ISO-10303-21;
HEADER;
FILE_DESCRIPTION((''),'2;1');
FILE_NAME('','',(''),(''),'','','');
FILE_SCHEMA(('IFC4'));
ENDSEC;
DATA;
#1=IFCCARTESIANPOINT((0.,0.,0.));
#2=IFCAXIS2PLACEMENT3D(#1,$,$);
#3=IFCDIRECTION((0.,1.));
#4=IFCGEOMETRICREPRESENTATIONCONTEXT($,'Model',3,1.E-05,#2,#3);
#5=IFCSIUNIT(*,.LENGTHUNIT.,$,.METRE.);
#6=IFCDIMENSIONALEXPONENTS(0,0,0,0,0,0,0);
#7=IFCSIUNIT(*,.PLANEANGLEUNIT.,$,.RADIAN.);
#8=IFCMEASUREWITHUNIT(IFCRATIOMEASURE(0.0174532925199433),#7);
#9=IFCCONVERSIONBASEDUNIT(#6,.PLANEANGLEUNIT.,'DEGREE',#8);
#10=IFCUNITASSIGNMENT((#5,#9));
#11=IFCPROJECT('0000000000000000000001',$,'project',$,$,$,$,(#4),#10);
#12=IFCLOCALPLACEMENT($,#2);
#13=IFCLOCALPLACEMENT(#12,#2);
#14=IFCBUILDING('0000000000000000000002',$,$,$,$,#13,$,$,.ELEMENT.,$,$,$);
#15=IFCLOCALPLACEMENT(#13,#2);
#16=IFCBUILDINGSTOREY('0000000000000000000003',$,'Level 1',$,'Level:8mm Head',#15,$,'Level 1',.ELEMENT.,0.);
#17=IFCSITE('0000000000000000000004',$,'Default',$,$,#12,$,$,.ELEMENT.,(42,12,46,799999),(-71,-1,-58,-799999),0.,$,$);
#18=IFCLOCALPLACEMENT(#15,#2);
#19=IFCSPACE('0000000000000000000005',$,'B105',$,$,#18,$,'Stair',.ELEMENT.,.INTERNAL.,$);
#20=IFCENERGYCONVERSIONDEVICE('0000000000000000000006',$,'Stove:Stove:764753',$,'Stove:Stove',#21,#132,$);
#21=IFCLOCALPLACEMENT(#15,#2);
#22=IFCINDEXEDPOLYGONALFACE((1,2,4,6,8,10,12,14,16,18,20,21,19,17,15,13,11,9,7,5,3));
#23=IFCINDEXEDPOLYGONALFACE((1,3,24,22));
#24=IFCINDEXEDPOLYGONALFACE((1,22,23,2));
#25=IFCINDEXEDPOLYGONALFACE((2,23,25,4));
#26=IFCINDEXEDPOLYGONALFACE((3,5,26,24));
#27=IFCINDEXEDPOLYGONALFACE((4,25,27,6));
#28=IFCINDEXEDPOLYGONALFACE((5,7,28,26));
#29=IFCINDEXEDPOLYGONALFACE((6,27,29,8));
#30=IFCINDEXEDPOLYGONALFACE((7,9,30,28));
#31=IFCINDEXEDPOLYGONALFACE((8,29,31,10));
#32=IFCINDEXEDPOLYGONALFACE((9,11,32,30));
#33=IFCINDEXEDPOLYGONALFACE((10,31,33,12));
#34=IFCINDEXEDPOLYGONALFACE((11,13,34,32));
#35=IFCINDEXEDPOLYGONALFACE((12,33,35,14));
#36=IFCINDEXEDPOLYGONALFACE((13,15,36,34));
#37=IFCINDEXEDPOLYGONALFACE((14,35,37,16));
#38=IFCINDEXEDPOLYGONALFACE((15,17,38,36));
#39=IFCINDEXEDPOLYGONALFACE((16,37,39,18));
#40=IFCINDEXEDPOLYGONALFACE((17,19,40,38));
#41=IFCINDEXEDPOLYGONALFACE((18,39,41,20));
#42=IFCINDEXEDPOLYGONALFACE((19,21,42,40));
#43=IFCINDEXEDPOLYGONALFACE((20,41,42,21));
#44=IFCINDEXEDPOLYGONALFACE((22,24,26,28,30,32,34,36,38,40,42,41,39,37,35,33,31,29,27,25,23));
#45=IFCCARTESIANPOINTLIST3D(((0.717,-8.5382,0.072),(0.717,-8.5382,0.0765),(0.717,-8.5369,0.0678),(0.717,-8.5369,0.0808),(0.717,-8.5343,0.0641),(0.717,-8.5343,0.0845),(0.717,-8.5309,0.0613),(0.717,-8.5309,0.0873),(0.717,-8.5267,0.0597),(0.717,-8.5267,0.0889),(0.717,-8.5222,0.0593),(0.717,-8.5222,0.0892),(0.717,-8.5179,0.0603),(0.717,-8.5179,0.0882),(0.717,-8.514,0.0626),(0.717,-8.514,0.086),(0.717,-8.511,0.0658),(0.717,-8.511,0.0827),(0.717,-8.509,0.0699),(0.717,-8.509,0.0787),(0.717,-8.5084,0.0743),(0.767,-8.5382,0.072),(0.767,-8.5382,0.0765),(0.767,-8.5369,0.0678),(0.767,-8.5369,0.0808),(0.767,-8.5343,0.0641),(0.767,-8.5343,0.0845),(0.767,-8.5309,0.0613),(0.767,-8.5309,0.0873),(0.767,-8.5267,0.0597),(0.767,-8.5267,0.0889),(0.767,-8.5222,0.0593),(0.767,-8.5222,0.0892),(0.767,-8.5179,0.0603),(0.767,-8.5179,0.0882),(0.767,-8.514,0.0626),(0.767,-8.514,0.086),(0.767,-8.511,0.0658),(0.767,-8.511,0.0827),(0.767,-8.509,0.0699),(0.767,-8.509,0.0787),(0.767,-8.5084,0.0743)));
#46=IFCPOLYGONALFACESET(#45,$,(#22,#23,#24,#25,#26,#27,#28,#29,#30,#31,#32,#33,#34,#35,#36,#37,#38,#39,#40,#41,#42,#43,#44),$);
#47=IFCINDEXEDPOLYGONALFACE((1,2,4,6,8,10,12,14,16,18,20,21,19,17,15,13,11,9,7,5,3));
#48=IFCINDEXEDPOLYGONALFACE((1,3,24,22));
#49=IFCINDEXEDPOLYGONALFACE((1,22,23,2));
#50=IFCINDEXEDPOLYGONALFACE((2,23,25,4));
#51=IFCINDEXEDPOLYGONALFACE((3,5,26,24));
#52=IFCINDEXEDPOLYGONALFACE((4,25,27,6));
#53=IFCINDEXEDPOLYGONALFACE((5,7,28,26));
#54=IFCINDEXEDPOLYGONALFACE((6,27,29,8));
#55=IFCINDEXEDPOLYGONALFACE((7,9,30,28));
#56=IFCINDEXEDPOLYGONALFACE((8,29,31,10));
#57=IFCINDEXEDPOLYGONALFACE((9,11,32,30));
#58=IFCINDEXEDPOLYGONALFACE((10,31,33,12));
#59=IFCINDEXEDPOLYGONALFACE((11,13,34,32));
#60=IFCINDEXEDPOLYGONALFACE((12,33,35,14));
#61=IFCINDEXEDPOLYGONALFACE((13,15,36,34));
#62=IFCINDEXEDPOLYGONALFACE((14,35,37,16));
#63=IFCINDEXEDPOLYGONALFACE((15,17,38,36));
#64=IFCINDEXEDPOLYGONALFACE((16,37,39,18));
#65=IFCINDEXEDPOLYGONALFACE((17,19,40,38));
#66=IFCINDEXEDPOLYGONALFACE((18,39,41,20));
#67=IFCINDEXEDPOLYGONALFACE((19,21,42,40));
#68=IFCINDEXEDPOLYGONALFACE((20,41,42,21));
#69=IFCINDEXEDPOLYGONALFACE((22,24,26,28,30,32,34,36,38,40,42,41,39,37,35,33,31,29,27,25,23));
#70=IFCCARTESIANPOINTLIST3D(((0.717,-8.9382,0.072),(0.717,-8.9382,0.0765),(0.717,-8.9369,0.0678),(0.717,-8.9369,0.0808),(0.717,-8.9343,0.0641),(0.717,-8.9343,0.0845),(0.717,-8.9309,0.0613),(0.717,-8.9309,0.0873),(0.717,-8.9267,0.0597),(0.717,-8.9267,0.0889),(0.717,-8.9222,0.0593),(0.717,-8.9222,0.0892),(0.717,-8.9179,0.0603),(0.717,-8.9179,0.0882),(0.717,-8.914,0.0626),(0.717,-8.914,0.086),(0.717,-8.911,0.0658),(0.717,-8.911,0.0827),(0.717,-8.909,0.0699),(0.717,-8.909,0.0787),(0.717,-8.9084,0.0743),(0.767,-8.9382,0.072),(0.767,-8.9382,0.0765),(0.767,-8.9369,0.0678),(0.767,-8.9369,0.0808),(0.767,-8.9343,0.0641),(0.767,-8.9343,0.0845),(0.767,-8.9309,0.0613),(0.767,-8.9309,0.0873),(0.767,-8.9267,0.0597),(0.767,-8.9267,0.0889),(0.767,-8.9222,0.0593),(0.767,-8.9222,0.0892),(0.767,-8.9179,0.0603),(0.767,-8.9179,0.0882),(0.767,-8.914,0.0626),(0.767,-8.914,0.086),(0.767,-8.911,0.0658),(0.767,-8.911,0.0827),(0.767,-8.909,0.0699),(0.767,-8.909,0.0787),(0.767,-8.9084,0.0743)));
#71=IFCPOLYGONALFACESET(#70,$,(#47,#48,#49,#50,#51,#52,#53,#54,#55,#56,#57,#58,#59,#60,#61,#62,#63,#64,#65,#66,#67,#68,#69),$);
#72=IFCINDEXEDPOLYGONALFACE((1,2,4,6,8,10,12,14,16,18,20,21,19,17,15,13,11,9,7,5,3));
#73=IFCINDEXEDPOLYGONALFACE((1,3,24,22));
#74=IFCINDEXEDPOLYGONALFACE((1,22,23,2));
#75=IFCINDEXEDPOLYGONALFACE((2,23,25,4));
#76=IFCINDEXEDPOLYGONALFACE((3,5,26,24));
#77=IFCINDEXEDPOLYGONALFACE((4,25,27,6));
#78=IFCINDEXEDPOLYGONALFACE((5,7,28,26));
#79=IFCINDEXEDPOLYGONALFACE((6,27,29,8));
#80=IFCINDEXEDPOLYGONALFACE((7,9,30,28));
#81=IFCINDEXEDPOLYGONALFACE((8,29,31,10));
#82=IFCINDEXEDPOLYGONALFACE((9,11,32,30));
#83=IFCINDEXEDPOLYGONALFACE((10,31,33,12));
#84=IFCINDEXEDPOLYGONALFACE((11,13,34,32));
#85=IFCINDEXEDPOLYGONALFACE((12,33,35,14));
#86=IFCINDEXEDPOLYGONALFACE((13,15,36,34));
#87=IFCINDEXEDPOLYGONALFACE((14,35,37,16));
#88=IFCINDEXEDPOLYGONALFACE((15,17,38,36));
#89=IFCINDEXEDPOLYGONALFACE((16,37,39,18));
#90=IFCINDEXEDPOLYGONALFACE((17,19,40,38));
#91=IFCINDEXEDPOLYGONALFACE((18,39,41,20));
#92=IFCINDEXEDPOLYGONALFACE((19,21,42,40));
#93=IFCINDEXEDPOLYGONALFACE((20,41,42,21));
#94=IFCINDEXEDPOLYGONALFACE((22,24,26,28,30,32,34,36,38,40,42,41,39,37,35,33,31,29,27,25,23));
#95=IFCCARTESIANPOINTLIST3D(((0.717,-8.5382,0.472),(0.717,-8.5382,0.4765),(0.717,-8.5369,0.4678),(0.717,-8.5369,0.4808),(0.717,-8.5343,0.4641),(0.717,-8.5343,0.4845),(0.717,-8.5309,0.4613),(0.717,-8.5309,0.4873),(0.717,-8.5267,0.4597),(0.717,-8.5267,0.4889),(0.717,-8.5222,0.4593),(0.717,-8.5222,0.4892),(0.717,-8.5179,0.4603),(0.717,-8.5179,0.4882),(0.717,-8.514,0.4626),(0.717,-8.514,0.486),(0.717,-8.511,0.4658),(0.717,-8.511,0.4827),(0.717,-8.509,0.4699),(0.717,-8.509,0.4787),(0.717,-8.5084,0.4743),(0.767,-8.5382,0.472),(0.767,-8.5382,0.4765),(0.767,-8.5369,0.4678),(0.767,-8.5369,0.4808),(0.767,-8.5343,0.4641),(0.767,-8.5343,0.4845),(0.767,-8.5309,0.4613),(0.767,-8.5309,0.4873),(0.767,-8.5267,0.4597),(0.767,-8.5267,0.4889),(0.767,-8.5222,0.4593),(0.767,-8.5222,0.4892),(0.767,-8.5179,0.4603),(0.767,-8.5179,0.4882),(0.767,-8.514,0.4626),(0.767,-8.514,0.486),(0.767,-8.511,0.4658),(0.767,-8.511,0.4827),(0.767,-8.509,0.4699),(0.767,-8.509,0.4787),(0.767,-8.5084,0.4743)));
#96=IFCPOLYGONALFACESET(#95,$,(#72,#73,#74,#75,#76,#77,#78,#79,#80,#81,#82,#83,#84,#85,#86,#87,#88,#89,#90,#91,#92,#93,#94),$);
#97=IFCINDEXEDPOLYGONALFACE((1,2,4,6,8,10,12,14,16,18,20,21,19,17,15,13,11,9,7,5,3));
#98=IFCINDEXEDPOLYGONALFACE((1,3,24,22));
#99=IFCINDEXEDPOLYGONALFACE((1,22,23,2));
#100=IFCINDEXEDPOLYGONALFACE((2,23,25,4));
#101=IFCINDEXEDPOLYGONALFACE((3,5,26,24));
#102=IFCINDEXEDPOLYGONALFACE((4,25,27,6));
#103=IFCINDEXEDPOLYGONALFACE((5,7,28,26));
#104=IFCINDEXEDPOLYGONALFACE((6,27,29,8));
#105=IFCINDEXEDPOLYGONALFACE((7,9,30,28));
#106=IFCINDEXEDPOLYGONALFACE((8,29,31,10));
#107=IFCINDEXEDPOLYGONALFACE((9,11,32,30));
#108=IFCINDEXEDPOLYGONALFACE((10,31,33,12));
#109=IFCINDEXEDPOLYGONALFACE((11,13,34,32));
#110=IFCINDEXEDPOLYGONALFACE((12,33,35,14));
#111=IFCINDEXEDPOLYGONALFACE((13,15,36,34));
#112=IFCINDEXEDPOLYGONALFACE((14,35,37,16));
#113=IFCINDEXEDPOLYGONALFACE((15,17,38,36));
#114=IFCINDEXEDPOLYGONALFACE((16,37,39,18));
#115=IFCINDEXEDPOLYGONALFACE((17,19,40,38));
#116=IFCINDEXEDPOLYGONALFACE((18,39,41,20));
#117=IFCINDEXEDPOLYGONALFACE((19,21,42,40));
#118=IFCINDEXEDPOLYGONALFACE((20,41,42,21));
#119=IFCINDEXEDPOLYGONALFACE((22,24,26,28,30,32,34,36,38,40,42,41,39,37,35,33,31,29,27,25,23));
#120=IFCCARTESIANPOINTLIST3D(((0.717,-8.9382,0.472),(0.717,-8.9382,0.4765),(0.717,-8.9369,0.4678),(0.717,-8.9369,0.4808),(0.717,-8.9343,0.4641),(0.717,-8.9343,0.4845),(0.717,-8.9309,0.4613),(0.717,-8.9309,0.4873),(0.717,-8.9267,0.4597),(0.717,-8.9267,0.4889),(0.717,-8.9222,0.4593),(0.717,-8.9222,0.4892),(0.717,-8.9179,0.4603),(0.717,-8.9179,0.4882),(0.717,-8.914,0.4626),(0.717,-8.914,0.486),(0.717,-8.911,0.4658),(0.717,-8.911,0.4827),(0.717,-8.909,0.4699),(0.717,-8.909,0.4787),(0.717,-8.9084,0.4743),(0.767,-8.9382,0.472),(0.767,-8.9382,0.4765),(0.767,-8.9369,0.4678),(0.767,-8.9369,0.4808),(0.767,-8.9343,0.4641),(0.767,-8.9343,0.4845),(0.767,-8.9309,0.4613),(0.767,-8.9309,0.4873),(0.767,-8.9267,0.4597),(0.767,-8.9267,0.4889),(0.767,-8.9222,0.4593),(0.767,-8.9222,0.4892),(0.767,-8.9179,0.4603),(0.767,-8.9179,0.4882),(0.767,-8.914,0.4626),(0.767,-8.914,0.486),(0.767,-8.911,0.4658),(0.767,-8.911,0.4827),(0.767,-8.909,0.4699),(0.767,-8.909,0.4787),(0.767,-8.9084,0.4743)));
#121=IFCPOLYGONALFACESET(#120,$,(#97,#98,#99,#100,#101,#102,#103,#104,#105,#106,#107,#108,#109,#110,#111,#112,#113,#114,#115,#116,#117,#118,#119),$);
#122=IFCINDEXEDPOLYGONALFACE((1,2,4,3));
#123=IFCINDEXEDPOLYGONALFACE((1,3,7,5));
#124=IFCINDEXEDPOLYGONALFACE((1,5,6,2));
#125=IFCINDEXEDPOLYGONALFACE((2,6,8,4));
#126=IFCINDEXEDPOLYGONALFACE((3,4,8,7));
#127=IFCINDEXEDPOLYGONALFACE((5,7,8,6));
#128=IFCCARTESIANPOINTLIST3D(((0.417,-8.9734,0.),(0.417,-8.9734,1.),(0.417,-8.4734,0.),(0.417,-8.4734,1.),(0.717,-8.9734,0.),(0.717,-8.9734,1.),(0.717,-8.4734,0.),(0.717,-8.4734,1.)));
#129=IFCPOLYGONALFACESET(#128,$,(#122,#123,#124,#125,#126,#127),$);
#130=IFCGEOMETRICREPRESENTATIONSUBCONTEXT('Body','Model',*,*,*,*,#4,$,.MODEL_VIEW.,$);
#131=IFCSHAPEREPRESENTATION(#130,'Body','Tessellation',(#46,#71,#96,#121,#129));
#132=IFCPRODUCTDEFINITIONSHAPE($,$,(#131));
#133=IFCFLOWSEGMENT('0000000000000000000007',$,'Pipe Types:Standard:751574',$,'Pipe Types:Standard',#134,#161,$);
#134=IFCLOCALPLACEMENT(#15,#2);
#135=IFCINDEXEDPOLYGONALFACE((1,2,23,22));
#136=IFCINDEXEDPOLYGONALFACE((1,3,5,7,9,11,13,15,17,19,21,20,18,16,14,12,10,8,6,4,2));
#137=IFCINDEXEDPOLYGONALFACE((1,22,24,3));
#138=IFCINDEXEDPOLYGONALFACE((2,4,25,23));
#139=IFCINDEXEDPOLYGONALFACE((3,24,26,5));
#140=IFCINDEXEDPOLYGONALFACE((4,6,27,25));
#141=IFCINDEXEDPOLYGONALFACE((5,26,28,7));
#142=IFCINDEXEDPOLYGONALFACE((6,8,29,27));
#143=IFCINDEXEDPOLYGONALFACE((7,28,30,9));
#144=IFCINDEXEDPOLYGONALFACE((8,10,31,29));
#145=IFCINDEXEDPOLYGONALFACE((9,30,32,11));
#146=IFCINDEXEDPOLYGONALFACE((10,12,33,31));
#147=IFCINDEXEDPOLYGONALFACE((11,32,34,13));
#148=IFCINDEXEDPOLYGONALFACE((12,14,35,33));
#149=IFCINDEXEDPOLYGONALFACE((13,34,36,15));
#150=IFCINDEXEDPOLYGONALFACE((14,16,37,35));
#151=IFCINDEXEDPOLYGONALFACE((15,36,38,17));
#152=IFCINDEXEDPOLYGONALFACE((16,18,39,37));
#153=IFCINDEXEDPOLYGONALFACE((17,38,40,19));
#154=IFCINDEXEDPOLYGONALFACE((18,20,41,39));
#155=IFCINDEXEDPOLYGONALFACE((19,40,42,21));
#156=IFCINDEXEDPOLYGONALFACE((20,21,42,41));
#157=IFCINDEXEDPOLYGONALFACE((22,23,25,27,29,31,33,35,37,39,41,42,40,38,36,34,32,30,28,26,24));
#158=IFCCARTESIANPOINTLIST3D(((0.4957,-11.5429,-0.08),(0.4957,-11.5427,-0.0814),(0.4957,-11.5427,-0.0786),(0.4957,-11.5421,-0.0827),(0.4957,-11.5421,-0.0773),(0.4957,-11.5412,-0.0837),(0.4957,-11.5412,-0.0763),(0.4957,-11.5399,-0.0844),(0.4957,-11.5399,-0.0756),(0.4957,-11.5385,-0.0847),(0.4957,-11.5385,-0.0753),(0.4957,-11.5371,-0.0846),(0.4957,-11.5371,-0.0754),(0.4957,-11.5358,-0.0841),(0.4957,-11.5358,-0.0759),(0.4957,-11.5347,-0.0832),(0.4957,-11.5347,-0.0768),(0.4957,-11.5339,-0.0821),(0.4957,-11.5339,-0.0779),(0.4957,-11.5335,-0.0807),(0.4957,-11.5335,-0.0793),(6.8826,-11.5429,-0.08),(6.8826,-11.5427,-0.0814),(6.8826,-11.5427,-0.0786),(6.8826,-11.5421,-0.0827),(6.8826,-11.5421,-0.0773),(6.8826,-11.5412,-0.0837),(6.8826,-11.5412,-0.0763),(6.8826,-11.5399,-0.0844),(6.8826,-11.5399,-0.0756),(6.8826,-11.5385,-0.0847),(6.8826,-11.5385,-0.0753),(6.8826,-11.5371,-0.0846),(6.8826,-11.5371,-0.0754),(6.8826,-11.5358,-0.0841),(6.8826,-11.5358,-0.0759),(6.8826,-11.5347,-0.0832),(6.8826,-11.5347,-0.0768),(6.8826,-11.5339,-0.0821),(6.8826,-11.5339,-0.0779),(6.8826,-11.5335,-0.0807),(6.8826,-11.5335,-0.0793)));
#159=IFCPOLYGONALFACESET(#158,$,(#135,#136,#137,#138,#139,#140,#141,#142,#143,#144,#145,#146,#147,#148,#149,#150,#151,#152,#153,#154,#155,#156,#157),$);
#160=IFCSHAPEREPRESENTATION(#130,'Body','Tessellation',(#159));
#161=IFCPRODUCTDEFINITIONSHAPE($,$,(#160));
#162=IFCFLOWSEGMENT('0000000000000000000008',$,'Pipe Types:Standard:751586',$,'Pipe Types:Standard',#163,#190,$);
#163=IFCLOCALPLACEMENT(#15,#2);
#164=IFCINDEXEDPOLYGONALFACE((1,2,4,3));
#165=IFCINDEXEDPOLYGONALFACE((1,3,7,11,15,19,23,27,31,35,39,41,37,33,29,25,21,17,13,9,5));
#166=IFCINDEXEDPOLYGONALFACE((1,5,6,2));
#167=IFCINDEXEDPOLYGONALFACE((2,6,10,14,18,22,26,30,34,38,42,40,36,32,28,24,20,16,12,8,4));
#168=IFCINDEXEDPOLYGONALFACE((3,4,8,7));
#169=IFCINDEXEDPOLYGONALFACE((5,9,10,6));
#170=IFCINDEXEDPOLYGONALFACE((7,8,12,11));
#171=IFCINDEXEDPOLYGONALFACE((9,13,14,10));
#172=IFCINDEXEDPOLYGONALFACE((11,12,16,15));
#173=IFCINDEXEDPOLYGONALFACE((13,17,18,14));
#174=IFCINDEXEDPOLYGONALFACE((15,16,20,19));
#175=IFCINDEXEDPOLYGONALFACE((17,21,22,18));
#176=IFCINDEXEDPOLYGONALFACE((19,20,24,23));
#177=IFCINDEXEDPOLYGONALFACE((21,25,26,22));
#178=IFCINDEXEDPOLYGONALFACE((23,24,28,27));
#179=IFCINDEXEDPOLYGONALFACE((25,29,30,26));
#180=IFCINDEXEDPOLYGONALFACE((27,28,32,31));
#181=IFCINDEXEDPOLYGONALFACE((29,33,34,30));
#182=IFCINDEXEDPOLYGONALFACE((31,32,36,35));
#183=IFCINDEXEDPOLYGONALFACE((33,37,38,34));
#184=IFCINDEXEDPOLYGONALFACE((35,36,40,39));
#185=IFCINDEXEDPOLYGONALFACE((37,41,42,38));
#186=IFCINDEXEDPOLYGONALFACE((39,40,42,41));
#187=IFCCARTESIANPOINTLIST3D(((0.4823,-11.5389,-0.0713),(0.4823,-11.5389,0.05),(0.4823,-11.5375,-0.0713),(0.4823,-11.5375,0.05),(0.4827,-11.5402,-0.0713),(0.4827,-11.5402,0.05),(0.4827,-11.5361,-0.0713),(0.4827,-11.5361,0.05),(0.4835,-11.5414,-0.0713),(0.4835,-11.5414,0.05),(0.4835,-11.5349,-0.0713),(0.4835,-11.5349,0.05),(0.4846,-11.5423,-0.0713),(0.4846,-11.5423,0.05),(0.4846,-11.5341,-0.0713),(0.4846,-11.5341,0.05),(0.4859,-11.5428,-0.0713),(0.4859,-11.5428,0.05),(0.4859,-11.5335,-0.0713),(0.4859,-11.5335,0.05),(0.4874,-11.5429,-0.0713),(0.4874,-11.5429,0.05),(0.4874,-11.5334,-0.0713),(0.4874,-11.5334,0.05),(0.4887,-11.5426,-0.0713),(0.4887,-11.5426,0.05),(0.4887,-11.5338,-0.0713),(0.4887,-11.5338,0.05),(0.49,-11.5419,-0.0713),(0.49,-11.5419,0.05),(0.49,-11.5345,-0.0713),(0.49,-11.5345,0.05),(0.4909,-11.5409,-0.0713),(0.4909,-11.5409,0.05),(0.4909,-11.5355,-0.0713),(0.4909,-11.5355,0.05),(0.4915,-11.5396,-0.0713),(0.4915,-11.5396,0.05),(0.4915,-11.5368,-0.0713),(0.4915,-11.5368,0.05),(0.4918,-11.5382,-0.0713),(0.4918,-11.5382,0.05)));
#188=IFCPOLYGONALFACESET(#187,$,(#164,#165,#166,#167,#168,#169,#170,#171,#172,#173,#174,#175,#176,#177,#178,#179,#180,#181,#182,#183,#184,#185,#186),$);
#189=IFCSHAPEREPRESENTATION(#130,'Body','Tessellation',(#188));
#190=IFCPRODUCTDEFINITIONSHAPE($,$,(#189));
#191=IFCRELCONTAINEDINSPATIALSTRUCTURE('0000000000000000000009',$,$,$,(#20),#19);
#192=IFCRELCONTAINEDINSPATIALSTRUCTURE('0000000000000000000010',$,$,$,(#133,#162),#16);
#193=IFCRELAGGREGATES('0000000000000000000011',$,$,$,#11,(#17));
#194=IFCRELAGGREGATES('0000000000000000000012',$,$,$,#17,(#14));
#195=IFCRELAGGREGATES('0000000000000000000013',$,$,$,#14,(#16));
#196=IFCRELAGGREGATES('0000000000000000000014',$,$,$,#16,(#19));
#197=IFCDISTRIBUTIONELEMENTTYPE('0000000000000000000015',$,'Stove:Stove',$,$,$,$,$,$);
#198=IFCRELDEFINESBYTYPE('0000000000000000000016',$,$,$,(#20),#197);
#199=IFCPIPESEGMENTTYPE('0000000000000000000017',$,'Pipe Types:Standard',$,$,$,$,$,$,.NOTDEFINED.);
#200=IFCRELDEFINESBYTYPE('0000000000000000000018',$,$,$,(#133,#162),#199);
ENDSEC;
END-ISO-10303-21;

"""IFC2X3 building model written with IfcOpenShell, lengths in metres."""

from ifc_helpers import new_model, entity, si_unit, converted_unit, direction, frame, frame_2d, origin, origin_2d_with_axis, place, context, subcontext, project, spatial, rectangle, circle, extrude, source, transform, mapped, type_object, type_shapes, element, save


model = new_model("IFC2X3")

# Units and contexts
model_context = context("Model", 3, precision=1e-05, world=origin(), true_north=direction((0.0, 1.0)))
body_context = subcontext(model_context, "Body", "Model", "MODEL_VIEW")
ifc_project = project(units=[si_unit("LENGTHUNIT", "METRE"), converted_unit("PLANEANGLEUNIT", "DEGREE", entity("IfcRatioMeasure", 0.0174532925199433), si_unit("PLANEANGLEUNIT", "RADIAN"), dimensions=[0, 0, 0, 0, 0, 0, 0])], contexts=[model_context])

# Site, building, storey
site_placement = place(None, origin())
site = spatial("IfcSite", under=ifc_project, at=site_placement, Name="Default", CompositionType="ELEMENT", RefLatitude=(42, 12, 46, 799999), RefLongitude=(-71, -1, -58, -799999), RefElevation=0.0)
building_placement = place(site_placement, origin())
building = spatial("IfcBuilding", under=site, at=building_placement, CompositionType="ELEMENT")
storey_placement = place(building_placement, origin())
storey = spatial("IfcBuildingStorey", under=building, at=storey_placement, Name="Level 1", ObjectType="Level:8mm Head", LongName="Level 1", CompositionType="ELEMENT", Elevation=0.0)

# Shared definitions
distribution_element_type_1 = type_object("IfcDistributionElementType", Name="Stove:Stove")
shared_shape_1 = source(origin(), body_context, "Body", "SweptSolid", [
    extrude(circle(Radius=0.015, at=frame_2d((0.0, 0.0), x_axis=(1.0, 0.0))), frame((0.2, -0.2, 0.0743), z_axis=(0.0, 1.0, 0.0), x_axis=(1.0, 0.0, 0.0)), (0.0, 0.0, 1.0), 0.05),
    extrude(circle(Radius=0.015, at=frame_2d((0.0, 0.0), x_axis=(1.0, 0.0))), frame((-0.2, -0.2, 0.0743), z_axis=(0.0, 1.0, 0.0), x_axis=(1.0, 0.0, 0.0)), (0.0, 0.0, 1.0), 0.05),
    extrude(circle(Radius=0.015, at=origin_2d_with_axis()), frame((0.2, -0.2, 0.4743), z_axis=(0.0, 1.0, 0.0), x_axis=(1.0, 0.0, 0.0)), (0.0, 0.0, 1.0), 0.05),
    extrude(circle(Radius=0.015, at=origin_2d_with_axis()), frame((-0.2, -0.2, 0.4743), z_axis=(0.0, 1.0, 0.0), x_axis=(1.0, 0.0, 0.0)), (0.0, 0.0, 1.0), 0.05),
    extrude(rectangle(XDim=0.5, YDim=0.3, at=origin_2d_with_axis()), frame((0.0, 0.0, 0.0), z_axis=(0.0, 0.0, 1.0), x_axis=(-1.0, 0.0, 0.0)), (0.0, 0.0, 1.0), 1.0),
])
type_shapes(distribution_element_type_1, [shared_shape_1])

# Shared definitions
space_1_placement = place(storey_placement, origin())
space_1 = spatial("IfcSpace", under=storey, at=space_1_placement, Name="B105", LongName="Stair", CompositionType="ELEMENT", InteriorOrExteriorSpace="INTERNAL")

# Energy conversion device
energy_conversion_device_1_placement = place(space_1_placement, frame((0.567, -8.7234, 0.0), z_axis=(0.0, 0.0, 1.0), x_axis=(0.0, 1.0, 0.0)))
element("IfcEnergyConversionDevice", 1, at=energy_conversion_device_1_placement, inside=space_1, type_object=distribution_element_type_1, Name="Stove:Stove:764753", ObjectType="Stove:Stove", context=body_context, shape_type="MappedRepresentation", body=[
    mapped(shared_shape_1, transform((0.0, 0.0, 0.0), scale=1.0)),
])

# Flow segments
pipe_segment_type = type_object("IfcPipeSegmentType", Name="Pipe Types:Standard", PredefinedType="NOTDEFINED")
flow_segment_1_placement = place(storey_placement, origin())
element("IfcFlowSegment", 2, at=flow_segment_1_placement, inside=storey, type_object=pipe_segment_type, Name="Pipe Types:Standard:751574", ObjectType="Pipe Types:Standard", context=body_context, shape_type="SweptSolid", body=[
    extrude(circle(Radius=0.0048, at=origin_2d_with_axis()), frame((0.4957, -11.5382, -0.08), z_axis=(1.0, 0.0, 0.0), x_axis=(0.0, -1.0, 0.0)), (0.0, 0.0, 1.0), 6.3868),
])
flow_segment_2_placement = place(storey_placement, origin())
element("IfcFlowSegment", 3, at=flow_segment_2_placement, inside=storey, type_object=pipe_segment_type, Name="Pipe Types:Standard:751586", ObjectType="Pipe Types:Standard", context=body_context, shape_type="SweptSolid", body=[
    extrude(circle(Radius=0.0048, at=origin_2d_with_axis()), frame((0.487, -11.5382, -0.0713)), (0.0, 0.0, 1.0), 0.1213),
])

save(model, "model.ifc")
